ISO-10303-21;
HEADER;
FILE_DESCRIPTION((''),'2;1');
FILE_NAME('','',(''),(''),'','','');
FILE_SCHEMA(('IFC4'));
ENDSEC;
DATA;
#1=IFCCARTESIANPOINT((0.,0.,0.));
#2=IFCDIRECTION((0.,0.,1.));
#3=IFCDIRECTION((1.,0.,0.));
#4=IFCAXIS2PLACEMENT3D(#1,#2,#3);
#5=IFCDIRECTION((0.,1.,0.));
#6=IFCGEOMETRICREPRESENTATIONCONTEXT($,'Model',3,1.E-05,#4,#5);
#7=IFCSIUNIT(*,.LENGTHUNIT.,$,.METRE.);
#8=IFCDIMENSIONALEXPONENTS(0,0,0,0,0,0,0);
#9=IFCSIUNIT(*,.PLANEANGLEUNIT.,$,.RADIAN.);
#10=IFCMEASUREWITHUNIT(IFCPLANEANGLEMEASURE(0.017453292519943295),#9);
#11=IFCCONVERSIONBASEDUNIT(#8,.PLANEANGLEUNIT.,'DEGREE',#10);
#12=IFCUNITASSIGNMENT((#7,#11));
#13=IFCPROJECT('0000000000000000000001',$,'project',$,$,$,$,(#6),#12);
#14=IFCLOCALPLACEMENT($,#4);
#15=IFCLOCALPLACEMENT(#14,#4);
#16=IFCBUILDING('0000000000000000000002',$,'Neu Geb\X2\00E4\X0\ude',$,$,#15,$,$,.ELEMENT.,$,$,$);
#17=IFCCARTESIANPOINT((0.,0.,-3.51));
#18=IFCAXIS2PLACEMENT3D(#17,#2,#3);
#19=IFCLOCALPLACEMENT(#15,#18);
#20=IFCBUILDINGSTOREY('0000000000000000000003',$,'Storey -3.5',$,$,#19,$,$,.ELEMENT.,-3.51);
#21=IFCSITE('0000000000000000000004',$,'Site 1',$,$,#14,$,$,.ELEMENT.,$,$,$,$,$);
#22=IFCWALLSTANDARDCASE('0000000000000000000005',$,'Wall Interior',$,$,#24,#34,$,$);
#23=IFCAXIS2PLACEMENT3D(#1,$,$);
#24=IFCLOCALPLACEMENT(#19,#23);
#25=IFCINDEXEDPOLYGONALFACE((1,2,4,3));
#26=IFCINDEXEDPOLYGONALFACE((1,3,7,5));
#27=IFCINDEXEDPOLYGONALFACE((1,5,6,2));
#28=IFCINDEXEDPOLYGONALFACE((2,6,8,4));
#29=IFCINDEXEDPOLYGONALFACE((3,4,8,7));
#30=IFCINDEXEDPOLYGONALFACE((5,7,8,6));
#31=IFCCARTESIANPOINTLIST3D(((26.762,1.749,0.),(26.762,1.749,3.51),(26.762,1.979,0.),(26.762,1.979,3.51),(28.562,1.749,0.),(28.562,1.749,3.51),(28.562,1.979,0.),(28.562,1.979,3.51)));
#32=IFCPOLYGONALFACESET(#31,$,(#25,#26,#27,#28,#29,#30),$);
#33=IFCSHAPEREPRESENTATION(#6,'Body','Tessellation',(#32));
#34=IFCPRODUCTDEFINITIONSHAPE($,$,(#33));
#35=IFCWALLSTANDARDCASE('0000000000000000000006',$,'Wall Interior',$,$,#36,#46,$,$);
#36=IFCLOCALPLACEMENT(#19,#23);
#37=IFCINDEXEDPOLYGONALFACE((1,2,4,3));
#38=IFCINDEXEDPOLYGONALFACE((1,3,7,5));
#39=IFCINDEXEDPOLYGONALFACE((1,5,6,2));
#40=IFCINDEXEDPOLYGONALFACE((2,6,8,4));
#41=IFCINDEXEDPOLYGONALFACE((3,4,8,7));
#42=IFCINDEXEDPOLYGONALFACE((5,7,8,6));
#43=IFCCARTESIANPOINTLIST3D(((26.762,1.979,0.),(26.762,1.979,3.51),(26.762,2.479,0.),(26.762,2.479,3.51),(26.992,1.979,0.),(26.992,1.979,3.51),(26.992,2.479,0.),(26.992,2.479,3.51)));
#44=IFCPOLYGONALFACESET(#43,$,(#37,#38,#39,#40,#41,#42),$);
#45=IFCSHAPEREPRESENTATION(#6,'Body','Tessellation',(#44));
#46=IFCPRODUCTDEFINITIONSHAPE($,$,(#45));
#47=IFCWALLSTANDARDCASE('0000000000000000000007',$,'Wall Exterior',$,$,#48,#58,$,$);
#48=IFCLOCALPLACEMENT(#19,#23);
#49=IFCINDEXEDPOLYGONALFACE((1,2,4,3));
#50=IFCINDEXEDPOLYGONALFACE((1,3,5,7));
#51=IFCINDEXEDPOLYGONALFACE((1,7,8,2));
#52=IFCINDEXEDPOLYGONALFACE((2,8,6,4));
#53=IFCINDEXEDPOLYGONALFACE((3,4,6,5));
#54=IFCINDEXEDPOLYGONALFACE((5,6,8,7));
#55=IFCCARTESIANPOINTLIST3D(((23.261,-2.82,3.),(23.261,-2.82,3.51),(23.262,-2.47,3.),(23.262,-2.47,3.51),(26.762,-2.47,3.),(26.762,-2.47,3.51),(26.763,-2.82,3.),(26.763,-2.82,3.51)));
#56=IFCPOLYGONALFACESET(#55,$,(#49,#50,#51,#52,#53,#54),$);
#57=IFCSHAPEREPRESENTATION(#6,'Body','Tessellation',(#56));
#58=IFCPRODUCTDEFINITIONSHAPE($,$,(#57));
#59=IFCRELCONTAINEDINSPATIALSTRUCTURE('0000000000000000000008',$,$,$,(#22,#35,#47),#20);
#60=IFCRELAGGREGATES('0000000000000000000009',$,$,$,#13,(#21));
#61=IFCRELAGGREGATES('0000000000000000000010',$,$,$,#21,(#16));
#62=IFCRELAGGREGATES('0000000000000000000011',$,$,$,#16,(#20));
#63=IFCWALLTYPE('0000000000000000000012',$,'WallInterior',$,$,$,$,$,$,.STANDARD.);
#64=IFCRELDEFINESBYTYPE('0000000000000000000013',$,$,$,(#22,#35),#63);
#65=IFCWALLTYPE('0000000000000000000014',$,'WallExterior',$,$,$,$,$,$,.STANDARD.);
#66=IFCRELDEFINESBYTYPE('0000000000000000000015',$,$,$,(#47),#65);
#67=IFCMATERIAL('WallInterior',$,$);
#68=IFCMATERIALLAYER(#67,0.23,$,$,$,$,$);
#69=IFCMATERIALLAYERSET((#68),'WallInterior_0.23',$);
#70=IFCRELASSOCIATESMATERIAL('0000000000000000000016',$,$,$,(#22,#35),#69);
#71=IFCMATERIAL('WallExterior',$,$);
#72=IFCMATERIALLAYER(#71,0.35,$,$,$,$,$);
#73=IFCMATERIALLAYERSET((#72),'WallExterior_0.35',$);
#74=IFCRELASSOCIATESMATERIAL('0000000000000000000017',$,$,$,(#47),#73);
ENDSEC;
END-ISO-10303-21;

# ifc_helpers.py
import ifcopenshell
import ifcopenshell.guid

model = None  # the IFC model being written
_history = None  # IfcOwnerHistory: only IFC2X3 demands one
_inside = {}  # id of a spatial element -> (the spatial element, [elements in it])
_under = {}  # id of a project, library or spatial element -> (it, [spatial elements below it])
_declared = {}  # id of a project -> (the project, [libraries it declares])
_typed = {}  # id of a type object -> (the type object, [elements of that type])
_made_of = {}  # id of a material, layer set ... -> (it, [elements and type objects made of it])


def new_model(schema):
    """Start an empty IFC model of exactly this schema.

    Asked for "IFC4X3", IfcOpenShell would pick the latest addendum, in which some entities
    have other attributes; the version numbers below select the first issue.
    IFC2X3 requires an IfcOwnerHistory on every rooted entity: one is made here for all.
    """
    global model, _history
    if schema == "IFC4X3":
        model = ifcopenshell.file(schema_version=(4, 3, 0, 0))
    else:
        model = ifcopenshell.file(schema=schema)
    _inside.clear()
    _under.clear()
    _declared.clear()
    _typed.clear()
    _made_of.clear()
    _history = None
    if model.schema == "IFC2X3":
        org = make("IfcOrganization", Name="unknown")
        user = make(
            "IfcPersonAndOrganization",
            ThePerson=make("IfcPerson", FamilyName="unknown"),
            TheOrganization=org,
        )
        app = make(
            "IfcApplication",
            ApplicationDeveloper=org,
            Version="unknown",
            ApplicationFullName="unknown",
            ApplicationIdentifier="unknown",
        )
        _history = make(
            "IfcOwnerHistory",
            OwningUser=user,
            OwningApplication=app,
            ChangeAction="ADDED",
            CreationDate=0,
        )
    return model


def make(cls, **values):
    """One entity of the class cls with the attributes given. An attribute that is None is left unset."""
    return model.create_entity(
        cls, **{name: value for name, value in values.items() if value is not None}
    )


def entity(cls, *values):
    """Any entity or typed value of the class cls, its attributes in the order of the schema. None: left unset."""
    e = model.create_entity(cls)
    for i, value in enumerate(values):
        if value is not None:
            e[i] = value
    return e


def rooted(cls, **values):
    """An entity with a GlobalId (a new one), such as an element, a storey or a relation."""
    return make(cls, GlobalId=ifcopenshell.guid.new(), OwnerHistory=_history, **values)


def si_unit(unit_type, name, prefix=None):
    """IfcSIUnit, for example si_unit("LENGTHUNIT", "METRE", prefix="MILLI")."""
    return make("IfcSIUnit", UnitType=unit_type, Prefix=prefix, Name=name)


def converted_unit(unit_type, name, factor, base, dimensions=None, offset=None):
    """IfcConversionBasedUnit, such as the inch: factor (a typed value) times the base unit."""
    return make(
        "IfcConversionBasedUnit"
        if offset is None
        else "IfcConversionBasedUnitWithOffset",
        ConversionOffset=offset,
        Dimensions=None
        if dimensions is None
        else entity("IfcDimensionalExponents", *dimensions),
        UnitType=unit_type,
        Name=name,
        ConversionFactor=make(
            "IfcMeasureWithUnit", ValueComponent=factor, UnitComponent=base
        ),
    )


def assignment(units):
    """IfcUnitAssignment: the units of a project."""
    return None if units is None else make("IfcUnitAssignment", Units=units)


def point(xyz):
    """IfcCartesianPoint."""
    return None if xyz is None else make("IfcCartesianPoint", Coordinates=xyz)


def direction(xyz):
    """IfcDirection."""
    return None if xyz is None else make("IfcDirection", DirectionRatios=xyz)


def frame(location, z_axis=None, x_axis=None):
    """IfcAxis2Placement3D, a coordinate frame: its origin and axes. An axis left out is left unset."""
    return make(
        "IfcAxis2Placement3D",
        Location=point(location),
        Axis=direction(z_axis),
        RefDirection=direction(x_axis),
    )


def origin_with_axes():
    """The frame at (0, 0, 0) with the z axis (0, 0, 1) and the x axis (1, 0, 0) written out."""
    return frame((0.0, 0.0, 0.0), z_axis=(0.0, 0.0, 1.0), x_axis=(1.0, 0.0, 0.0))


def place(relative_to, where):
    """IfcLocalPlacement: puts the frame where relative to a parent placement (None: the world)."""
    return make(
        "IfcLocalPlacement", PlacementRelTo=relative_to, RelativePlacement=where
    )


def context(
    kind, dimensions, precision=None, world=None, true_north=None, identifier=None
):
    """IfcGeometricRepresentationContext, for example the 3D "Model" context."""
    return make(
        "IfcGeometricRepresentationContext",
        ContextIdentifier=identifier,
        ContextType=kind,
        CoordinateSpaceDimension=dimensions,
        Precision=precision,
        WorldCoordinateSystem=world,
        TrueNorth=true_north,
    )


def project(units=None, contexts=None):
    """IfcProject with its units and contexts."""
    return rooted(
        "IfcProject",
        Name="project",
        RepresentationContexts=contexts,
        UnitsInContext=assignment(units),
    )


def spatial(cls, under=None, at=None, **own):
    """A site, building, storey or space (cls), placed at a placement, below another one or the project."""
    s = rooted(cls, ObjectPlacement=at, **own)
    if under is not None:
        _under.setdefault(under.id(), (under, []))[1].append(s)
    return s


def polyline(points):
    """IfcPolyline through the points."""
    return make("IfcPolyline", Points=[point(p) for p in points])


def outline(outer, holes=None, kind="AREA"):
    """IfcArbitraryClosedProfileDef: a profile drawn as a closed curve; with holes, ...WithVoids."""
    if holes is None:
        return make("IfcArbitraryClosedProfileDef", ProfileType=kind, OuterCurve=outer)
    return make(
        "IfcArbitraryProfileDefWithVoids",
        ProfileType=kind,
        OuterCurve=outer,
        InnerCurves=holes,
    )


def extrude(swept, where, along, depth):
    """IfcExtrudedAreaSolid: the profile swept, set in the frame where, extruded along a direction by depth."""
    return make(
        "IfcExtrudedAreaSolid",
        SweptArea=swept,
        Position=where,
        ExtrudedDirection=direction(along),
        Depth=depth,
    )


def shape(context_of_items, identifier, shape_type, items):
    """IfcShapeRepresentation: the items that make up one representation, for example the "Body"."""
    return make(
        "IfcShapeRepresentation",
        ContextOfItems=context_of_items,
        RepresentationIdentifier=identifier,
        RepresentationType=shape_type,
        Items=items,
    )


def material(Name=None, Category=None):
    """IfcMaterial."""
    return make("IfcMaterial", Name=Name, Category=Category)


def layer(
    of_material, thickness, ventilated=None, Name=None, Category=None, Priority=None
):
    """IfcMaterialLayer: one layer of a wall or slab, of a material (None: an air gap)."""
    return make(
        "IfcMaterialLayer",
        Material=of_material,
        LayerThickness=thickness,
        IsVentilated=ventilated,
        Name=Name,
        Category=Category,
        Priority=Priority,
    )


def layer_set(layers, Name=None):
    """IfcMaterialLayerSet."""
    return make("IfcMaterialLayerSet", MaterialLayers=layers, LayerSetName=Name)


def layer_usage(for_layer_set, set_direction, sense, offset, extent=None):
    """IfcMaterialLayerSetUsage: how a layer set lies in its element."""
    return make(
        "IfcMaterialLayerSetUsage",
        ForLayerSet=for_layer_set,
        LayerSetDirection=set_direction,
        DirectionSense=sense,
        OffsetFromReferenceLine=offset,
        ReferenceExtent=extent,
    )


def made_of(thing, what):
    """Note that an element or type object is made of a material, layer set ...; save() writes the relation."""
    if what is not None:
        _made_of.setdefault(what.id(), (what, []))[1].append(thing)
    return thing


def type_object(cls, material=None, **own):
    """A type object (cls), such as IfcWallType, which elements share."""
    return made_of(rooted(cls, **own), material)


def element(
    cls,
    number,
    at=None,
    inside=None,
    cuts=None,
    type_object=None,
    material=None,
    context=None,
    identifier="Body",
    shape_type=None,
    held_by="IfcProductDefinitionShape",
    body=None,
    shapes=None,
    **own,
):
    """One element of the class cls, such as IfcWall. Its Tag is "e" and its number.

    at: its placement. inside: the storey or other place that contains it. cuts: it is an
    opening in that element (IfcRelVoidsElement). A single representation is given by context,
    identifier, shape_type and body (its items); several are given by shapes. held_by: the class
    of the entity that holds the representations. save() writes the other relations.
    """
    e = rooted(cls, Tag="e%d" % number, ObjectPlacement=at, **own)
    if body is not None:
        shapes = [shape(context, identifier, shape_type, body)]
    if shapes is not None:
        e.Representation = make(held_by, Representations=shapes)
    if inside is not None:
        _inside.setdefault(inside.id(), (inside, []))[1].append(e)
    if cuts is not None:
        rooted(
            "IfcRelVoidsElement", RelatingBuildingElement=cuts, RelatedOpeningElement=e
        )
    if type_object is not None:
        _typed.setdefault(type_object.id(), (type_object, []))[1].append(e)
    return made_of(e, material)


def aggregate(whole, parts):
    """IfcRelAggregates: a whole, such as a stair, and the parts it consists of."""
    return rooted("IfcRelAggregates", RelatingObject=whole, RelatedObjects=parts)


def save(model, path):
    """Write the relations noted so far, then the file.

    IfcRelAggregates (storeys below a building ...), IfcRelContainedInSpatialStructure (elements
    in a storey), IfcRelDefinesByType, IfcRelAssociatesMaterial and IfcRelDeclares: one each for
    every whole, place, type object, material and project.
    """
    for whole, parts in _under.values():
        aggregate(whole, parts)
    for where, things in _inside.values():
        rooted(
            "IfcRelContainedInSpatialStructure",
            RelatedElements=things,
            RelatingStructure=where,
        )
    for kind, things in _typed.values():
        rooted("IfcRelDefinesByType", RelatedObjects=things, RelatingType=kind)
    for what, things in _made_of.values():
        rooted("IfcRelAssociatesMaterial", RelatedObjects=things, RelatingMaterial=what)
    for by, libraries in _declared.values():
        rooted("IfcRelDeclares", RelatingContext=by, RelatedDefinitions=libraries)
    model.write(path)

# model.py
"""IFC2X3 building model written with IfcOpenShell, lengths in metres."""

from ifc_helpers import new_model, entity, si_unit, converted_unit, direction, frame, origin_with_axes, place, context, project, spatial, polyline, outline, extrude, material, layer, layer_set, layer_usage, type_object, element, save


model = new_model("IFC2X3")

# Units and contexts
model_context = context("Model", 3, precision=1e-05, world=origin_with_axes(), true_north=direction((0.0, 1.0, 0.0)))
ifc_project = project(units=[si_unit("LENGTHUNIT", "METRE"), converted_unit("PLANEANGLEUNIT", "DEGREE", entity("IfcPlaneAngleMeasure", 0.017453292519943295), si_unit("PLANEANGLEUNIT", "RADIAN"), dimensions=[0, 0, 0, 0, 0, 0, 0])], contexts=[model_context])

# Site, building, storey
site_placement = place(None, origin_with_axes())
site = spatial("IfcSite", under=ifc_project, at=site_placement, Name="Site 1", CompositionType="ELEMENT")
building_placement = place(site_placement, origin_with_axes())
building = spatial("IfcBuilding", under=site, at=building_placement, Name="Neu Gebäude", CompositionType="ELEMENT")
storey_placement = place(building_placement, frame((0.0, 0.0, -3.51), z_axis=(0.0, 0.0, 1.0), x_axis=(1.0, 0.0, 0.0)))
storey = spatial("IfcBuildingStorey", under=building, at=storey_placement, Name="Storey -3.5", CompositionType="ELEMENT", Elevation=-3.51)

# Shared definitions
ifc_material_1 = material(Name="WallInterior")
wall_type_1 = type_object("IfcWallType", Name="WallInterior", PredefinedType="STANDARD")
ifc_layer_1 = layer(ifc_material_1, 0.23)
ifc_layer_set_1 = layer_set([ifc_layer_1], Name="WallInterior_0.23")
ifc_layer_usage_1 = layer_usage(ifc_layer_set_1, "AXIS2", "POSITIVE", -0.115)

# Walls
wall_1_placement = place(storey_placement, frame((28.562, 1.864, 0.0), z_axis=(0.0, 0.0, 1.0), x_axis=(-1.0, 0.0, 0.0)))
element("IfcWallStandardCase", 1, at=wall_1_placement, inside=storey, type_object=wall_type_1, material=ifc_layer_usage_1, Name="Wall Interior", context=model_context, shape_type="SweptSolid", body=[
    extrude(outline(polyline([(0.0, -0.115), (1.8, -0.115), (1.8, 0.115), (0.0, 0.115), (0.0, -0.115)])), origin_with_axes(), (0.0, 0.0, 1.0), 3.51),
])
wall_2_placement = place(storey_placement, frame((26.877, 1.979, 0.0), z_axis=(0.0, 0.0, 1.0), x_axis=(0.0, 1.0, 0.0)))
element("IfcWallStandardCase", 2, at=wall_2_placement, inside=storey, type_object=wall_type_1, material=ifc_layer_usage_1, Name="Wall Interior", context=model_context, shape_type="SweptSolid", body=[
    extrude(outline(polyline([(0.5, -0.115), (0.5, 0.115), (0.0, 0.115), (0.0, -0.115), (0.5, -0.115)])), origin_with_axes(), (0.0, 0.0, 1.0), 3.51),
])
ifc_material_2 = material(Name="WallExterior")
ifc_layer_2 = layer(ifc_material_2, 0.35)
ifc_layer_set_2 = layer_set([ifc_layer_2], Name="WallExterior_0.35")
ifc_layer_usage_2 = layer_usage(ifc_layer_set_2, "AXIS2", "POSITIVE", -0.175)
wall_type_2 = type_object("IfcWallType", Name="WallExterior", PredefinedType="STANDARD")
wall_3_placement = place(storey_placement, frame((26.763, -2.645, 3.0), z_axis=(0.0, 0.0, 1.0), x_axis=(-1.0, 0.0, 0.0)))
element("IfcWallStandardCase", 3, at=wall_3_placement, inside=storey, type_object=wall_type_2, material=ifc_layer_usage_2, Name="Wall Exterior", context=model_context, shape_type="SweptSolid", body=[
    extrude(outline(polyline([(0.001, -0.175), (3.501, -0.175), (3.502, 0.175), (0.0, 0.175), (0.001, -0.175)])), origin_with_axes(), (0.0, 0.0, 1.0), 0.51),
])

save(model, "model.ifc")
